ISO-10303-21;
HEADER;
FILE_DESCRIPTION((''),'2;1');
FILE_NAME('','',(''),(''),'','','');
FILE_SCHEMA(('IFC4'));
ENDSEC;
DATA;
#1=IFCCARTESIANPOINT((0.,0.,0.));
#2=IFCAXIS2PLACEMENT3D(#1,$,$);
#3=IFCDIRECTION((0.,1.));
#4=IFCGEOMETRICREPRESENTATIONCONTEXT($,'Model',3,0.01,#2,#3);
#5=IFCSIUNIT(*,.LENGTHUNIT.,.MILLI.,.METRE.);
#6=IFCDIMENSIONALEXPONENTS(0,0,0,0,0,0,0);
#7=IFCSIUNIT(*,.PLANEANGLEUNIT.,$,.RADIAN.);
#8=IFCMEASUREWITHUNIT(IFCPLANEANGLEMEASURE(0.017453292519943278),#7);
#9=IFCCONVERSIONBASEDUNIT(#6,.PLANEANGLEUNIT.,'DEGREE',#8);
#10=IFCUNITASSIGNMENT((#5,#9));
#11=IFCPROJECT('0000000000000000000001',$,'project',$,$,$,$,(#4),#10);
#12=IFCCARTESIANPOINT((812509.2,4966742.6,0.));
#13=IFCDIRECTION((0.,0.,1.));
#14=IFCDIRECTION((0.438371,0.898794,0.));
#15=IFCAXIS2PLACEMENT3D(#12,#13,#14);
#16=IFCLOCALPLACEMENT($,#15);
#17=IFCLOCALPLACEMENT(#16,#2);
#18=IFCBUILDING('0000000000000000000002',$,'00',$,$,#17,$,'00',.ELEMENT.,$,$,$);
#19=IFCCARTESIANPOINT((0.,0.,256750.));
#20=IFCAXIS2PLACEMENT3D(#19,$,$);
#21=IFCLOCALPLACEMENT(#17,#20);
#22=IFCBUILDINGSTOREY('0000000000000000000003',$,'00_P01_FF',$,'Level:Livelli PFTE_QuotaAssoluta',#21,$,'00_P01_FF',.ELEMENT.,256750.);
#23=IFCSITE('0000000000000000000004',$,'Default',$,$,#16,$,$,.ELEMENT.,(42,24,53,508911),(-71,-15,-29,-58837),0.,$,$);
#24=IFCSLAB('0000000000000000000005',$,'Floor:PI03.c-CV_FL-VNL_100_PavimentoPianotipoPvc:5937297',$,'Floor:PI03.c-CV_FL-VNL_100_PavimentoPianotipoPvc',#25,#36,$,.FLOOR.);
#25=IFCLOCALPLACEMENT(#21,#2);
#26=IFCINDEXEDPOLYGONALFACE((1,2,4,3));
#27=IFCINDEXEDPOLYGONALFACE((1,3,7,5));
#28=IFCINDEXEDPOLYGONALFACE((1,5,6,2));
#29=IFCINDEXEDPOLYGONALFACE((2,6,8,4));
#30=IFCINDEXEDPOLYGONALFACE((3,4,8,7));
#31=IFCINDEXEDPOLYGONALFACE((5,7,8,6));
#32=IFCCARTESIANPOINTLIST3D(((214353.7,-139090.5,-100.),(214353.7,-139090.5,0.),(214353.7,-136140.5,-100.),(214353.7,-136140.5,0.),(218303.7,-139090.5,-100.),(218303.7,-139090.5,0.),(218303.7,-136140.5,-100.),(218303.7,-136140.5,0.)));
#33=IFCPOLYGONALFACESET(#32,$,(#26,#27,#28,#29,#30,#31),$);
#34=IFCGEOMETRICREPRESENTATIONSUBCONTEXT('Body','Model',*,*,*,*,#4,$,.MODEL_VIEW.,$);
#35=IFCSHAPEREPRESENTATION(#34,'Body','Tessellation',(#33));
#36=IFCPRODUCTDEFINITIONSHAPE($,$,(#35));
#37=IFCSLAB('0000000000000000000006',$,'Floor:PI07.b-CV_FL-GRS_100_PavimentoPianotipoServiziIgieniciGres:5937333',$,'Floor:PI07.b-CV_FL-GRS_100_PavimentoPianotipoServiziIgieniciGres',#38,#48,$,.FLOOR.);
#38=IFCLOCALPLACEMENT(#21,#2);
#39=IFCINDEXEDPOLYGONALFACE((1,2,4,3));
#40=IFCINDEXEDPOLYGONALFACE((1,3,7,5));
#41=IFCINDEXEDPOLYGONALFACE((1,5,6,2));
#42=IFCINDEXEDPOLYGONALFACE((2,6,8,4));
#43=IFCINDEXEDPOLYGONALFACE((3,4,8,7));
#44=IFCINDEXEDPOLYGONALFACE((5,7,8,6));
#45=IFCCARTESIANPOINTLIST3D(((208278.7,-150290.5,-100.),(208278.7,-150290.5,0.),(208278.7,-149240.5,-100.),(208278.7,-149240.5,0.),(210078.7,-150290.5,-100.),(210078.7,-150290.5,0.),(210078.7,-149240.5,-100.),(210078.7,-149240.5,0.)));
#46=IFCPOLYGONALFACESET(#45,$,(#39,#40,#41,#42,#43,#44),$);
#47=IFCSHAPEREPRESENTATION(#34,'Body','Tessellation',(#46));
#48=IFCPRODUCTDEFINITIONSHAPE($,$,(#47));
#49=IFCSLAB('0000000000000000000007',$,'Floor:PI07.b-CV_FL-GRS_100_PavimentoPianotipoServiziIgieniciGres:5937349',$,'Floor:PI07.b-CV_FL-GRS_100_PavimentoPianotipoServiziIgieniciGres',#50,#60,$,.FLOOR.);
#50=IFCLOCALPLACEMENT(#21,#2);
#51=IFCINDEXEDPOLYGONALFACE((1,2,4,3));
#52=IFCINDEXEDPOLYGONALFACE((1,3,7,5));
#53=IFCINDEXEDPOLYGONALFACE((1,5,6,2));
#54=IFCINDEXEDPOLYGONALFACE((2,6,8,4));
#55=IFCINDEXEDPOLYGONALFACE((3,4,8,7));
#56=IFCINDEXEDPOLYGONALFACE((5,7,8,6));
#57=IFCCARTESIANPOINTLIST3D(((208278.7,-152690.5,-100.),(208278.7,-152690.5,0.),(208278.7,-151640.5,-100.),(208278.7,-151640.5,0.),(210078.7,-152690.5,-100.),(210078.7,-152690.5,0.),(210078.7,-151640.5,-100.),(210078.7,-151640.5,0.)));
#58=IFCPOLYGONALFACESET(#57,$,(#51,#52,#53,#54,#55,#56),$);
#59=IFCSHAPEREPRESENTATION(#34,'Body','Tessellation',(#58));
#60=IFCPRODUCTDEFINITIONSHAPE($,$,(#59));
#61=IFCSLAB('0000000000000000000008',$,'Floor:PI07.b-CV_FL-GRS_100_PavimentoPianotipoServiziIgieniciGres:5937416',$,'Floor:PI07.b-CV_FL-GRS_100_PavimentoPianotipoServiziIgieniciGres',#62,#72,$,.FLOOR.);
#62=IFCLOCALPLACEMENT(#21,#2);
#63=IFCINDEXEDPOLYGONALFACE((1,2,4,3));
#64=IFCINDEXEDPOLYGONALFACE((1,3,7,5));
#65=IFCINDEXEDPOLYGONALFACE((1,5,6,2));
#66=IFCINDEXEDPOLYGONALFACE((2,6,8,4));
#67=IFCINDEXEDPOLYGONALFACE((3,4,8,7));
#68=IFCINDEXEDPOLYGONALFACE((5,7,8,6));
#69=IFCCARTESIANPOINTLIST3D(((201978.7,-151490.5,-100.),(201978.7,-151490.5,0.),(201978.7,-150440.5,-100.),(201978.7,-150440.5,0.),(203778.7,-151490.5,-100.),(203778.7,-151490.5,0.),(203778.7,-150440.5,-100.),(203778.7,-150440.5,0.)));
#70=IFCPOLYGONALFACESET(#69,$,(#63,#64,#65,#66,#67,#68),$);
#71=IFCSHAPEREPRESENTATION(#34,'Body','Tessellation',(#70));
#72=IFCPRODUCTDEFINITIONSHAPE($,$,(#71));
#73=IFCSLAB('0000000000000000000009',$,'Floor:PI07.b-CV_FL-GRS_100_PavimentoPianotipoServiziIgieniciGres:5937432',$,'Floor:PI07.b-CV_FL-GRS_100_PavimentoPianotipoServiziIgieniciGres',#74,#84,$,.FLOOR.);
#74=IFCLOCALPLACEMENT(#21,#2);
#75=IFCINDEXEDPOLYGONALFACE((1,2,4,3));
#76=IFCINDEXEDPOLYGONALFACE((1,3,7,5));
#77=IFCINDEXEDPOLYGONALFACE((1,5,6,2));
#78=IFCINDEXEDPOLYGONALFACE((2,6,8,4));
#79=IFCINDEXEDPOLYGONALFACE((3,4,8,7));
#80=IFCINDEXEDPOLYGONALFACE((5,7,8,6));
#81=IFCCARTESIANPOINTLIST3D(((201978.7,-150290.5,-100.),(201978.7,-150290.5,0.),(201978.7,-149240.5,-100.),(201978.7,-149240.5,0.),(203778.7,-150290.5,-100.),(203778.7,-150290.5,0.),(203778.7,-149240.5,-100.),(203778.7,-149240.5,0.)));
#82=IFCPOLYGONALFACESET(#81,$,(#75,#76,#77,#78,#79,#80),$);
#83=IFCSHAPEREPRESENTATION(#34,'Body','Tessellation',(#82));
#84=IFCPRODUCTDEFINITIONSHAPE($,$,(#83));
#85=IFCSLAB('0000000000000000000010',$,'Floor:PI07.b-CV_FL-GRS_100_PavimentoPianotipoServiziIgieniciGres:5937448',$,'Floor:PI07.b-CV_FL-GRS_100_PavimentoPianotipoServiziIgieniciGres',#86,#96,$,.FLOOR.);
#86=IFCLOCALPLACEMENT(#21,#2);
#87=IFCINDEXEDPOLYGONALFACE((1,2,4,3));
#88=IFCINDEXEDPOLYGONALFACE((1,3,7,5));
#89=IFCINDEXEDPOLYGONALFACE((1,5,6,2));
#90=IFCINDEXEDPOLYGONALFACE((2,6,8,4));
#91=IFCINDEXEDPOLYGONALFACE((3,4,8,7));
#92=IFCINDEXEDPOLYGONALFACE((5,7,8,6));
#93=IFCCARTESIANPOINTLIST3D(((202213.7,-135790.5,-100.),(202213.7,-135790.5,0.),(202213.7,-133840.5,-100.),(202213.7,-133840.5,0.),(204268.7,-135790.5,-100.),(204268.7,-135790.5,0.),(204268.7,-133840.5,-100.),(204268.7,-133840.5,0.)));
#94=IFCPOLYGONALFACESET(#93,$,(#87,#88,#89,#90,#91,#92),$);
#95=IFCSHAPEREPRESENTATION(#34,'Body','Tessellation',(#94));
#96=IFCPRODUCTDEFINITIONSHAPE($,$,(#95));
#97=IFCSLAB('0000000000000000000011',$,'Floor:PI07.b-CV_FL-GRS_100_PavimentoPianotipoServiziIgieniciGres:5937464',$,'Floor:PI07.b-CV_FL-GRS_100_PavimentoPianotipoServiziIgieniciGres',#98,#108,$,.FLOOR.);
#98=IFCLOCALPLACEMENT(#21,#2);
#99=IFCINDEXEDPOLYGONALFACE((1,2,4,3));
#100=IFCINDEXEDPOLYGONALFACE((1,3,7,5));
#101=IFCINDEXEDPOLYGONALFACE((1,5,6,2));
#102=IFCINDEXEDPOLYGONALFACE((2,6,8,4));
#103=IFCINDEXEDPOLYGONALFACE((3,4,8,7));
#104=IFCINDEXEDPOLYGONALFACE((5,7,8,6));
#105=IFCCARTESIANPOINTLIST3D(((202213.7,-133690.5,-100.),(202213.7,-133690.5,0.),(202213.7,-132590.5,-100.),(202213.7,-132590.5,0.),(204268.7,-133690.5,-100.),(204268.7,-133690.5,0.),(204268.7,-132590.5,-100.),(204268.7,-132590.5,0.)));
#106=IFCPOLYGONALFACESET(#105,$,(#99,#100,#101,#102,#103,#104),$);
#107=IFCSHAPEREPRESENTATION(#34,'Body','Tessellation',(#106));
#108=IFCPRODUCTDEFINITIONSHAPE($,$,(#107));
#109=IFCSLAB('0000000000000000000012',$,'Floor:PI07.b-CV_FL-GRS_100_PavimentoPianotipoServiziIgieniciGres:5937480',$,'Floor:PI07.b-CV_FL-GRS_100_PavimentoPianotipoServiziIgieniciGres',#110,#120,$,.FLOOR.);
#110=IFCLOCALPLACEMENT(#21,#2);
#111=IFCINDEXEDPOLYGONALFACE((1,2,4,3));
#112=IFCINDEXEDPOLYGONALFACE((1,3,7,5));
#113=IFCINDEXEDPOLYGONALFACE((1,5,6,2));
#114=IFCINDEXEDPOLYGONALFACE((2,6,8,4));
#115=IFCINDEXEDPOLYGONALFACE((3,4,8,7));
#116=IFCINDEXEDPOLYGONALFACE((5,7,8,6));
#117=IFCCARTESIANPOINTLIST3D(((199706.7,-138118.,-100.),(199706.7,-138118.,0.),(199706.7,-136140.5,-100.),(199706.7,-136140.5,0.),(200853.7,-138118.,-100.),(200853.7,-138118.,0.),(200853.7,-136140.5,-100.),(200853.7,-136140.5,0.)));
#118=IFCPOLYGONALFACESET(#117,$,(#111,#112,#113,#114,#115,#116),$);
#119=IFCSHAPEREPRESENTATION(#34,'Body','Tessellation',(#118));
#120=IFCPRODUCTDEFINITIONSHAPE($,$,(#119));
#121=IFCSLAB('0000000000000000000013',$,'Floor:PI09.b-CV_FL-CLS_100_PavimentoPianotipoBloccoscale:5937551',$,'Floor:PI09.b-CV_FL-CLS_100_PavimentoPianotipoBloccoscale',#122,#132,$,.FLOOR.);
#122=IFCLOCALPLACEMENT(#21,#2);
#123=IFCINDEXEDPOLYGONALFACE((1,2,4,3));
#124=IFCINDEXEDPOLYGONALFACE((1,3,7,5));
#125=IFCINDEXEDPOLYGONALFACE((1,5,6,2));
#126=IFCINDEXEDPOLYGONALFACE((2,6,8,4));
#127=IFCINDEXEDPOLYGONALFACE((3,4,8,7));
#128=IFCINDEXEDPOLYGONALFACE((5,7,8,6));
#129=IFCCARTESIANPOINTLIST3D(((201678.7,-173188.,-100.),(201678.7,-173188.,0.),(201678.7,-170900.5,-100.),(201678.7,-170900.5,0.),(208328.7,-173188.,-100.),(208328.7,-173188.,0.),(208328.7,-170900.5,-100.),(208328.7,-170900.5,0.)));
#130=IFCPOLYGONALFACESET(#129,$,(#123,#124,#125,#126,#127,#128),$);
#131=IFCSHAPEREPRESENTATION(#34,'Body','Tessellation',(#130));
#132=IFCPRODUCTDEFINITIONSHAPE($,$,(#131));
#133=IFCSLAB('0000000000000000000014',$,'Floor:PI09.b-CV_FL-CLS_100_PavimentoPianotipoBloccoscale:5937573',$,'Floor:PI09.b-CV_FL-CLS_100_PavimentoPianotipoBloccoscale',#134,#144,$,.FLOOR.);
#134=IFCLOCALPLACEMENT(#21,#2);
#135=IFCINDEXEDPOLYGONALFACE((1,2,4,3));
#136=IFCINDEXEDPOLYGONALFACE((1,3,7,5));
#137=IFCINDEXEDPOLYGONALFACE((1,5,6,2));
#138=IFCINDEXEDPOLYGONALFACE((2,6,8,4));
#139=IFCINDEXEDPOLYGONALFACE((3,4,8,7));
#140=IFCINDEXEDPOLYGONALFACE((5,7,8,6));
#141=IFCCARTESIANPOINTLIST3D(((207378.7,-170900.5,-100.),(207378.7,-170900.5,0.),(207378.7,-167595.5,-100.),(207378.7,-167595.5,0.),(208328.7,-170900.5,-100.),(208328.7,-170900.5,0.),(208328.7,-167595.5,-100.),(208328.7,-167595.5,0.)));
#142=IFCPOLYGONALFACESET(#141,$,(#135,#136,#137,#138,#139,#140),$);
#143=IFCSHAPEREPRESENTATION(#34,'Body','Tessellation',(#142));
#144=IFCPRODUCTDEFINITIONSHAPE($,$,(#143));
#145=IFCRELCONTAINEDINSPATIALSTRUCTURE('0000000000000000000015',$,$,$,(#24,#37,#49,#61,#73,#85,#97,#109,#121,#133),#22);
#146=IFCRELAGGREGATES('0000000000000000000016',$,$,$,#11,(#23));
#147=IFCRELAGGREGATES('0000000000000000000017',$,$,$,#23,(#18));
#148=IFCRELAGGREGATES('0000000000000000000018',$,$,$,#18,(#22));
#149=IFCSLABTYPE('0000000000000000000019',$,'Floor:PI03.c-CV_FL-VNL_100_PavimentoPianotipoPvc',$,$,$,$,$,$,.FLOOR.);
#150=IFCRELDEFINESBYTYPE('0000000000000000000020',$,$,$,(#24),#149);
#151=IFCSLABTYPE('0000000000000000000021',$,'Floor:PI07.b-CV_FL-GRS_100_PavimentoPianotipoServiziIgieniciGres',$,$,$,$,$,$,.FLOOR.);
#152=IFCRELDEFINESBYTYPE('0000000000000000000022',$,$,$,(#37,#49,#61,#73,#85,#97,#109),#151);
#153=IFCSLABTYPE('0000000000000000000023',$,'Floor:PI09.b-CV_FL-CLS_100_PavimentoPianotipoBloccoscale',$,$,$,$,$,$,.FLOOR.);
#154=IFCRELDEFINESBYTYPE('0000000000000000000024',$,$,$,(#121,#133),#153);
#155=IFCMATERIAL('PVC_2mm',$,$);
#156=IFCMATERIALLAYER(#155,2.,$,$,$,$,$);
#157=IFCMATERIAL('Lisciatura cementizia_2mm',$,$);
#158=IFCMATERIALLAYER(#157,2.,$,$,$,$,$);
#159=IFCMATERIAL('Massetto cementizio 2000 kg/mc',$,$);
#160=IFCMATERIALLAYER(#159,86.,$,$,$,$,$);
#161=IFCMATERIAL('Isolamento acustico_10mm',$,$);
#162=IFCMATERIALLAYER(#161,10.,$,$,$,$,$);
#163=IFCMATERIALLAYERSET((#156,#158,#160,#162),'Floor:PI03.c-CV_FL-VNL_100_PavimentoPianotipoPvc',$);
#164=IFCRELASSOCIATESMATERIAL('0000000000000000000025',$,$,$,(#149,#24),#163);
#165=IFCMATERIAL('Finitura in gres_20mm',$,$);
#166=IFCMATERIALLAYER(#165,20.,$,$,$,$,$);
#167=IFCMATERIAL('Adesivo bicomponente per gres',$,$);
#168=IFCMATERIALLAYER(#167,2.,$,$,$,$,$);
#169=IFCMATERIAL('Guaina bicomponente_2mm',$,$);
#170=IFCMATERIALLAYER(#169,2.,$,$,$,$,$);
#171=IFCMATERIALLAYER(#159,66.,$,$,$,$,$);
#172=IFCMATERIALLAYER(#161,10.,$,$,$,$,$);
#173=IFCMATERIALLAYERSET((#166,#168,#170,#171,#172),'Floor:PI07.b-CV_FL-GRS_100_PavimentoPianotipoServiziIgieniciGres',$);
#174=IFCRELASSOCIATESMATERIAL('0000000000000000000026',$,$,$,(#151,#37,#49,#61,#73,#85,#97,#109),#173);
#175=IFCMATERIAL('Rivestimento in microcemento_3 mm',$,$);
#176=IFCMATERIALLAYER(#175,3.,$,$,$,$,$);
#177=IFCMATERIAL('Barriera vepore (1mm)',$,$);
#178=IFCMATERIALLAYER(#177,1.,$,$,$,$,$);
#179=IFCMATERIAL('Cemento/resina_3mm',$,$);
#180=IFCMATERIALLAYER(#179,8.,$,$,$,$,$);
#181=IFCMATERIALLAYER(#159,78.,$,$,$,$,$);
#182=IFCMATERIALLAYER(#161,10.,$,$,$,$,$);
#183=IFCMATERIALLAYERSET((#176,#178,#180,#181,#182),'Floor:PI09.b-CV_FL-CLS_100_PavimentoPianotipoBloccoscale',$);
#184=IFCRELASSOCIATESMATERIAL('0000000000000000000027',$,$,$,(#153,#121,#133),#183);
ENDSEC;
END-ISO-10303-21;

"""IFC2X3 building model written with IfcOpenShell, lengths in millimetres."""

from ifc_helpers import new_model, entity, si_unit, converted_unit, direction, frame, frame_2d, origin, place, context, subcontext, project, spatial, rectangle, extrude, material, layer, layer_set, layer_usage, type_object, element, save


model = new_model("IFC2X3")

# Units and contexts
model_context = context("Model", 3, precision=0.01, world=origin(), true_north=direction((0.0, 1.0)))
body_context = subcontext(model_context, "Body", "Model", "MODEL_VIEW")
ifc_project = project(units=[si_unit("LENGTHUNIT", "METRE", prefix="MILLI"), converted_unit("PLANEANGLEUNIT", "DEGREE", entity("IfcPlaneAngleMeasure", 0.017453292519943278), si_unit("PLANEANGLEUNIT", "RADIAN"), dimensions=[0, 0, 0, 0, 0, 0, 0])], contexts=[model_context])

# Site, building, storey
site_placement = place(None, frame((812509.2, 4966742.6, 0.0), z_axis=(0.0, 0.0, 1.0), x_axis=(0.438371, 0.898794, 0.0)))
site = spatial("IfcSite", under=ifc_project, at=site_placement, Name="Default", CompositionType="ELEMENT", RefLatitude=(42, 24, 53, 508911), RefLongitude=(-71, -15, -29, -58837), RefElevation=0.0)
building_placement = place(site_placement, origin())
building = spatial("IfcBuilding", under=site, at=building_placement, Name="00", LongName="00", CompositionType="ELEMENT")
storey_placement = place(building_placement, frame((0.0, 0.0, 256750.0)))
storey = spatial("IfcBuildingStorey", under=building, at=storey_placement, Name="00_P01_FF", ObjectType="Level:Livelli PFTE_QuotaAssoluta", LongName="00_P01_FF", CompositionType="ELEMENT", Elevation=256750.0)

# Slabs
ifc_material_1 = material(Name="PVC_2mm")
ifc_layer_1 = layer(ifc_material_1, 2.0)
ifc_material_2 = material(Name="Lisciatura cementizia_2mm")
ifc_layer_2 = layer(ifc_material_2, 2.0)
ifc_material_3 = material(Name="Massetto cementizio 2000 kg/mc")
ifc_layer_3 = layer(ifc_material_3, 86.0)
ifc_material_4 = material(Name="Isolamento acustico_10mm")
ifc_layer_4 = layer(ifc_material_4, 10.0)
ifc_layer_set_1 = layer_set([ifc_layer_1, ifc_layer_2, ifc_layer_3, ifc_layer_4], Name="Floor:PI03.c-CV_FL-VNL_100_PavimentoPianotipoPvc")
slab_type_1 = type_object("IfcSlabType", Name="Floor:PI03.c-CV_FL-VNL_100_PavimentoPianotipoPvc", PredefinedType="FLOOR", material=ifc_layer_set_1)
ifc_layer_usage_1 = layer_usage(ifc_layer_set_1, "AXIS3", "POSITIVE", 0.0)
slab_1_placement = place(storey_placement, origin())
element("IfcSlab", 1, at=slab_1_placement, inside=storey, type_object=slab_type_1, material=ifc_layer_usage_1, Name="Floor:PI03.c-CV_FL-VNL_100_PavimentoPianotipoPvc:5937297", ObjectType="Floor:PI03.c-CV_FL-VNL_100_PavimentoPianotipoPvc", PredefinedType="FLOOR", context=body_context, shape_type="SweptSolid", body=[
    extrude(rectangle(XDim=2950.0, YDim=3950.0, at=frame_2d((0.0, 0.0), x_axis=(1.0, 0.0))), frame((216328.7, -137615.5, 0.0), z_axis=(0.0, 0.0, -1.0), x_axis=(0.0, 1.0, 0.0)), (0.0, 0.0, 1.0), 100.0),
])
ifc_material_5 = material(Name="Finitura in gres_20mm")
ifc_layer_5 = layer(ifc_material_5, 20.0)
ifc_material_6 = material(Name="Adesivo bicomponente per gres")
ifc_layer_6 = layer(ifc_material_6, 2.0)
ifc_material_7 = material(Name="Guaina bicomponente_2mm")
ifc_layer_7 = layer(ifc_material_7, 2.0)
ifc_layer_8 = layer(ifc_material_3, 66.0)
ifc_layer_9 = layer(ifc_material_4, 10.0)
ifc_layer_set_2 = layer_set([ifc_layer_5, ifc_layer_6, ifc_layer_7, ifc_layer_8, ifc_layer_9], Name="Floor:PI07.b-CV_FL-GRS_100_PavimentoPianotipoServiziIgieniciGres")
ifc_layer_usage_2 = layer_usage(ifc_layer_set_2, "AXIS3", "POSITIVE", 0.0)
slab_type_2 = type_object("IfcSlabType", Name="Floor:PI07.b-CV_FL-GRS_100_PavimentoPianotipoServiziIgieniciGres", PredefinedType="FLOOR", material=ifc_layer_set_2)
slab_2_placement = place(storey_placement, origin())
element("IfcSlab", 2, at=slab_2_placement, inside=storey, type_object=slab_type_2, material=ifc_layer_usage_2, Name="Floor:PI07.b-CV_FL-GRS_100_PavimentoPianotipoServiziIgieniciGres:5937333", ObjectType="Floor:PI07.b-CV_FL-GRS_100_PavimentoPianotipoServiziIgieniciGres", PredefinedType="FLOOR", context=body_context, shape_type="SweptSolid", body=[
    extrude(rectangle(XDim=1050.0, YDim=1800.0, at=frame_2d((0.0, 0.0), x_axis=(1.0, 0.0))), frame((209178.7, -149765.5, 0.0), z_axis=(0.0, 0.0, -1.0), x_axis=(0.0, 1.0, 0.0)), (0.0, 0.0, 1.0), 100.0),
])
ifc_layer_usage_3 = layer_usage(ifc_layer_set_2, "AXIS3", "POSITIVE", 0.0)
slab_3_placement = place(storey_placement, origin())
element("IfcSlab", 3, at=slab_3_placement, inside=storey, type_object=slab_type_2, material=ifc_layer_usage_3, Name="Floor:PI07.b-CV_FL-GRS_100_PavimentoPianotipoServiziIgieniciGres:5937349", ObjectType="Floor:PI07.b-CV_FL-GRS_100_PavimentoPianotipoServiziIgieniciGres", PredefinedType="FLOOR", context=body_context, shape_type="SweptSolid", body=[
    extrude(rectangle(XDim=1050.0, YDim=1800.0, at=frame_2d((0.0, 0.0), x_axis=(1.0, 0.0))), frame((209178.7, -152165.5, 0.0), z_axis=(0.0, 0.0, -1.0), x_axis=(0.0, 1.0, 0.0)), (0.0, 0.0, 1.0), 100.0),
])
ifc_layer_usage_4 = layer_usage(ifc_layer_set_2, "AXIS3", "POSITIVE", 0.0)
slab_4_placement = place(storey_placement, origin())
element("IfcSlab", 4, at=slab_4_placement, inside=storey, type_object=slab_type_2, material=ifc_layer_usage_4, Name="Floor:PI07.b-CV_FL-GRS_100_PavimentoPianotipoServiziIgieniciGres:5937416", ObjectType="Floor:PI07.b-CV_FL-GRS_100_PavimentoPianotipoServiziIgieniciGres", PredefinedType="FLOOR", context=body_context, shape_type="SweptSolid", body=[
    extrude(rectangle(XDim=1050.0, YDim=1800.0, at=frame_2d((0.0, 0.0), x_axis=(1.0, 0.0))), frame((202878.7, -150965.5, 0.0), z_axis=(0.0, 0.0, -1.0), x_axis=(0.0, 1.0, 0.0)), (0.0, 0.0, 1.0), 100.0),
])
ifc_layer_usage_5 = layer_usage(ifc_layer_set_2, "AXIS3", "POSITIVE", 0.0)
slab_5_placement = place(storey_placement, origin())
element("IfcSlab", 5, at=slab_5_placement, inside=storey, type_object=slab_type_2, material=ifc_layer_usage_5, Name="Floor:PI07.b-CV_FL-GRS_100_PavimentoPianotipoServiziIgieniciGres:5937432", ObjectType="Floor:PI07.b-CV_FL-GRS_100_PavimentoPianotipoServiziIgieniciGres", PredefinedType="FLOOR", context=body_context, shape_type="SweptSolid", body=[
    extrude(rectangle(XDim=1050.0, YDim=1800.0, at=frame_2d((0.0, 0.0), x_axis=(1.0, 0.0))), frame((202878.7, -149765.5, 0.0), z_axis=(0.0, 0.0, -1.0), x_axis=(0.0, 1.0, 0.0)), (0.0, 0.0, 1.0), 100.0),
])
ifc_layer_usage_6 = layer_usage(ifc_layer_set_2, "AXIS3", "POSITIVE", 0.0)
slab_6_placement = place(storey_placement, origin())
element("IfcSlab", 6, at=slab_6_placement, inside=storey, type_object=slab_type_2, material=ifc_layer_usage_6, Name="Floor:PI07.b-CV_FL-GRS_100_PavimentoPianotipoServiziIgieniciGres:5937448", ObjectType="Floor:PI07.b-CV_FL-GRS_100_PavimentoPianotipoServiziIgieniciGres", PredefinedType="FLOOR", context=body_context, shape_type="SweptSolid", body=[
    extrude(rectangle(XDim=1950.0, YDim=2055.0, at=frame_2d((0.0, 0.0), x_axis=(1.0, 0.0))), frame((203241.2, -134815.5, 0.0), z_axis=(0.0, 0.0, -1.0), x_axis=(0.0, 1.0, 0.0)), (0.0, 0.0, 1.0), 100.0),
])
ifc_layer_usage_7 = layer_usage(ifc_layer_set_2, "AXIS3", "POSITIVE", 0.0)
slab_7_placement = place(storey_placement, origin())
element("IfcSlab", 7, at=slab_7_placement, inside=storey, type_object=slab_type_2, material=ifc_layer_usage_7, Name="Floor:PI07.b-CV_FL-GRS_100_PavimentoPianotipoServiziIgieniciGres:5937464", ObjectType="Floor:PI07.b-CV_FL-GRS_100_PavimentoPianotipoServiziIgieniciGres", PredefinedType="FLOOR", context=body_context, shape_type="SweptSolid", body=[
    extrude(rectangle(XDim=1100.0, YDim=2055.0, at=frame_2d((0.0, 0.0), x_axis=(1.0, 0.0))), frame((203241.2, -133140.5, 0.0), z_axis=(0.0, 0.0, -1.0), x_axis=(0.0, 1.0, 0.0)), (0.0, 0.0, 1.0), 100.0),
])
ifc_layer_usage_8 = layer_usage(ifc_layer_set_2, "AXIS3", "POSITIVE", 0.0)
slab_8_placement = place(storey_placement, origin())
element("IfcSlab", 8, at=slab_8_placement, inside=storey, type_object=slab_type_2, material=ifc_layer_usage_8, Name="Floor:PI07.b-CV_FL-GRS_100_PavimentoPianotipoServiziIgieniciGres:5937480", ObjectType="Floor:PI07.b-CV_FL-GRS_100_PavimentoPianotipoServiziIgieniciGres", PredefinedType="FLOOR", context=body_context, shape_type="SweptSolid", body=[
    extrude(rectangle(XDim=1977.5, YDim=1147.0, at=frame_2d((0.0, 0.0), x_axis=(1.0, 0.0))), frame((200280.2, -137129.2, 0.0), z_axis=(0.0, 0.0, -1.0), x_axis=(0.0, 1.0, 0.0)), (0.0, 0.0, 1.0), 100.0),
])

# Slabs
ifc_material_8 = material(Name="Rivestimento in microcemento_3 mm")
ifc_layer_10 = layer(ifc_material_8, 3.0)
ifc_material_9 = material(Name="Barriera vepore (1mm)")
ifc_layer_11 = layer(ifc_material_9, 1.0)
ifc_material_10 = material(Name="Cemento/resina_3mm")
ifc_layer_12 = layer(ifc_material_10, 8.0)
ifc_layer_13 = layer(ifc_material_3, 78.0)
ifc_layer_14 = layer(ifc_material_4, 10.0)
ifc_layer_set_3 = layer_set([ifc_layer_10, ifc_layer_11, ifc_layer_12, ifc_layer_13, ifc_layer_14], Name="Floor:PI09.b-CV_FL-CLS_100_PavimentoPianotipoBloccoscale")
slab_type_3 = type_object("IfcSlabType", Name="Floor:PI09.b-CV_FL-CLS_100_PavimentoPianotipoBloccoscale", PredefinedType="FLOOR", material=ifc_layer_set_3)
ifc_layer_usage_9 = layer_usage(ifc_layer_set_3, "AXIS3", "POSITIVE", 0.0)
slab_9_placement = place(storey_placement, origin())
element("IfcSlab", 9, at=slab_9_placement, inside=storey, type_object=slab_type_3, material=ifc_layer_usage_9, Name="Floor:PI09.b-CV_FL-CLS_100_PavimentoPianotipoBloccoscale:5937551", ObjectType="Floor:PI09.b-CV_FL-CLS_100_PavimentoPianotipoBloccoscale", PredefinedType="FLOOR", context=body_context, shape_type="SweptSolid", body=[
    extrude(rectangle(XDim=2287.5, YDim=6650.0, at=frame_2d((0.0, 0.0), x_axis=(1.0, 0.0))), frame((205003.7, -172044.2, 0.0), z_axis=(0.0, 0.0, -1.0), x_axis=(0.0, -1.0, 0.0)), (0.0, 0.0, 1.0), 100.0),
])
ifc_layer_usage_10 = layer_usage(ifc_layer_set_3, "AXIS3", "POSITIVE", 0.0)
slab_10_placement = place(storey_placement, origin())
element("IfcSlab", 10, at=slab_10_placement, inside=storey, type_object=slab_type_3, material=ifc_layer_usage_10, Name="Floor:PI09.b-CV_FL-CLS_100_PavimentoPianotipoBloccoscale:5937573", ObjectType="Floor:PI09.b-CV_FL-CLS_100_PavimentoPianotipoBloccoscale", PredefinedType="FLOOR", context=body_context, shape_type="SweptSolid", body=[
    extrude(rectangle(XDim=3305.0, YDim=950.0, at=frame_2d((0.0, 0.0), x_axis=(1.0, 0.0))), frame((207853.7, -169248.0, 0.0), z_axis=(0.0, 0.0, -1.0), x_axis=(0.0, 1.0, 0.0)), (0.0, 0.0, 1.0), 100.0),
])

save(model, "model.ifc")
